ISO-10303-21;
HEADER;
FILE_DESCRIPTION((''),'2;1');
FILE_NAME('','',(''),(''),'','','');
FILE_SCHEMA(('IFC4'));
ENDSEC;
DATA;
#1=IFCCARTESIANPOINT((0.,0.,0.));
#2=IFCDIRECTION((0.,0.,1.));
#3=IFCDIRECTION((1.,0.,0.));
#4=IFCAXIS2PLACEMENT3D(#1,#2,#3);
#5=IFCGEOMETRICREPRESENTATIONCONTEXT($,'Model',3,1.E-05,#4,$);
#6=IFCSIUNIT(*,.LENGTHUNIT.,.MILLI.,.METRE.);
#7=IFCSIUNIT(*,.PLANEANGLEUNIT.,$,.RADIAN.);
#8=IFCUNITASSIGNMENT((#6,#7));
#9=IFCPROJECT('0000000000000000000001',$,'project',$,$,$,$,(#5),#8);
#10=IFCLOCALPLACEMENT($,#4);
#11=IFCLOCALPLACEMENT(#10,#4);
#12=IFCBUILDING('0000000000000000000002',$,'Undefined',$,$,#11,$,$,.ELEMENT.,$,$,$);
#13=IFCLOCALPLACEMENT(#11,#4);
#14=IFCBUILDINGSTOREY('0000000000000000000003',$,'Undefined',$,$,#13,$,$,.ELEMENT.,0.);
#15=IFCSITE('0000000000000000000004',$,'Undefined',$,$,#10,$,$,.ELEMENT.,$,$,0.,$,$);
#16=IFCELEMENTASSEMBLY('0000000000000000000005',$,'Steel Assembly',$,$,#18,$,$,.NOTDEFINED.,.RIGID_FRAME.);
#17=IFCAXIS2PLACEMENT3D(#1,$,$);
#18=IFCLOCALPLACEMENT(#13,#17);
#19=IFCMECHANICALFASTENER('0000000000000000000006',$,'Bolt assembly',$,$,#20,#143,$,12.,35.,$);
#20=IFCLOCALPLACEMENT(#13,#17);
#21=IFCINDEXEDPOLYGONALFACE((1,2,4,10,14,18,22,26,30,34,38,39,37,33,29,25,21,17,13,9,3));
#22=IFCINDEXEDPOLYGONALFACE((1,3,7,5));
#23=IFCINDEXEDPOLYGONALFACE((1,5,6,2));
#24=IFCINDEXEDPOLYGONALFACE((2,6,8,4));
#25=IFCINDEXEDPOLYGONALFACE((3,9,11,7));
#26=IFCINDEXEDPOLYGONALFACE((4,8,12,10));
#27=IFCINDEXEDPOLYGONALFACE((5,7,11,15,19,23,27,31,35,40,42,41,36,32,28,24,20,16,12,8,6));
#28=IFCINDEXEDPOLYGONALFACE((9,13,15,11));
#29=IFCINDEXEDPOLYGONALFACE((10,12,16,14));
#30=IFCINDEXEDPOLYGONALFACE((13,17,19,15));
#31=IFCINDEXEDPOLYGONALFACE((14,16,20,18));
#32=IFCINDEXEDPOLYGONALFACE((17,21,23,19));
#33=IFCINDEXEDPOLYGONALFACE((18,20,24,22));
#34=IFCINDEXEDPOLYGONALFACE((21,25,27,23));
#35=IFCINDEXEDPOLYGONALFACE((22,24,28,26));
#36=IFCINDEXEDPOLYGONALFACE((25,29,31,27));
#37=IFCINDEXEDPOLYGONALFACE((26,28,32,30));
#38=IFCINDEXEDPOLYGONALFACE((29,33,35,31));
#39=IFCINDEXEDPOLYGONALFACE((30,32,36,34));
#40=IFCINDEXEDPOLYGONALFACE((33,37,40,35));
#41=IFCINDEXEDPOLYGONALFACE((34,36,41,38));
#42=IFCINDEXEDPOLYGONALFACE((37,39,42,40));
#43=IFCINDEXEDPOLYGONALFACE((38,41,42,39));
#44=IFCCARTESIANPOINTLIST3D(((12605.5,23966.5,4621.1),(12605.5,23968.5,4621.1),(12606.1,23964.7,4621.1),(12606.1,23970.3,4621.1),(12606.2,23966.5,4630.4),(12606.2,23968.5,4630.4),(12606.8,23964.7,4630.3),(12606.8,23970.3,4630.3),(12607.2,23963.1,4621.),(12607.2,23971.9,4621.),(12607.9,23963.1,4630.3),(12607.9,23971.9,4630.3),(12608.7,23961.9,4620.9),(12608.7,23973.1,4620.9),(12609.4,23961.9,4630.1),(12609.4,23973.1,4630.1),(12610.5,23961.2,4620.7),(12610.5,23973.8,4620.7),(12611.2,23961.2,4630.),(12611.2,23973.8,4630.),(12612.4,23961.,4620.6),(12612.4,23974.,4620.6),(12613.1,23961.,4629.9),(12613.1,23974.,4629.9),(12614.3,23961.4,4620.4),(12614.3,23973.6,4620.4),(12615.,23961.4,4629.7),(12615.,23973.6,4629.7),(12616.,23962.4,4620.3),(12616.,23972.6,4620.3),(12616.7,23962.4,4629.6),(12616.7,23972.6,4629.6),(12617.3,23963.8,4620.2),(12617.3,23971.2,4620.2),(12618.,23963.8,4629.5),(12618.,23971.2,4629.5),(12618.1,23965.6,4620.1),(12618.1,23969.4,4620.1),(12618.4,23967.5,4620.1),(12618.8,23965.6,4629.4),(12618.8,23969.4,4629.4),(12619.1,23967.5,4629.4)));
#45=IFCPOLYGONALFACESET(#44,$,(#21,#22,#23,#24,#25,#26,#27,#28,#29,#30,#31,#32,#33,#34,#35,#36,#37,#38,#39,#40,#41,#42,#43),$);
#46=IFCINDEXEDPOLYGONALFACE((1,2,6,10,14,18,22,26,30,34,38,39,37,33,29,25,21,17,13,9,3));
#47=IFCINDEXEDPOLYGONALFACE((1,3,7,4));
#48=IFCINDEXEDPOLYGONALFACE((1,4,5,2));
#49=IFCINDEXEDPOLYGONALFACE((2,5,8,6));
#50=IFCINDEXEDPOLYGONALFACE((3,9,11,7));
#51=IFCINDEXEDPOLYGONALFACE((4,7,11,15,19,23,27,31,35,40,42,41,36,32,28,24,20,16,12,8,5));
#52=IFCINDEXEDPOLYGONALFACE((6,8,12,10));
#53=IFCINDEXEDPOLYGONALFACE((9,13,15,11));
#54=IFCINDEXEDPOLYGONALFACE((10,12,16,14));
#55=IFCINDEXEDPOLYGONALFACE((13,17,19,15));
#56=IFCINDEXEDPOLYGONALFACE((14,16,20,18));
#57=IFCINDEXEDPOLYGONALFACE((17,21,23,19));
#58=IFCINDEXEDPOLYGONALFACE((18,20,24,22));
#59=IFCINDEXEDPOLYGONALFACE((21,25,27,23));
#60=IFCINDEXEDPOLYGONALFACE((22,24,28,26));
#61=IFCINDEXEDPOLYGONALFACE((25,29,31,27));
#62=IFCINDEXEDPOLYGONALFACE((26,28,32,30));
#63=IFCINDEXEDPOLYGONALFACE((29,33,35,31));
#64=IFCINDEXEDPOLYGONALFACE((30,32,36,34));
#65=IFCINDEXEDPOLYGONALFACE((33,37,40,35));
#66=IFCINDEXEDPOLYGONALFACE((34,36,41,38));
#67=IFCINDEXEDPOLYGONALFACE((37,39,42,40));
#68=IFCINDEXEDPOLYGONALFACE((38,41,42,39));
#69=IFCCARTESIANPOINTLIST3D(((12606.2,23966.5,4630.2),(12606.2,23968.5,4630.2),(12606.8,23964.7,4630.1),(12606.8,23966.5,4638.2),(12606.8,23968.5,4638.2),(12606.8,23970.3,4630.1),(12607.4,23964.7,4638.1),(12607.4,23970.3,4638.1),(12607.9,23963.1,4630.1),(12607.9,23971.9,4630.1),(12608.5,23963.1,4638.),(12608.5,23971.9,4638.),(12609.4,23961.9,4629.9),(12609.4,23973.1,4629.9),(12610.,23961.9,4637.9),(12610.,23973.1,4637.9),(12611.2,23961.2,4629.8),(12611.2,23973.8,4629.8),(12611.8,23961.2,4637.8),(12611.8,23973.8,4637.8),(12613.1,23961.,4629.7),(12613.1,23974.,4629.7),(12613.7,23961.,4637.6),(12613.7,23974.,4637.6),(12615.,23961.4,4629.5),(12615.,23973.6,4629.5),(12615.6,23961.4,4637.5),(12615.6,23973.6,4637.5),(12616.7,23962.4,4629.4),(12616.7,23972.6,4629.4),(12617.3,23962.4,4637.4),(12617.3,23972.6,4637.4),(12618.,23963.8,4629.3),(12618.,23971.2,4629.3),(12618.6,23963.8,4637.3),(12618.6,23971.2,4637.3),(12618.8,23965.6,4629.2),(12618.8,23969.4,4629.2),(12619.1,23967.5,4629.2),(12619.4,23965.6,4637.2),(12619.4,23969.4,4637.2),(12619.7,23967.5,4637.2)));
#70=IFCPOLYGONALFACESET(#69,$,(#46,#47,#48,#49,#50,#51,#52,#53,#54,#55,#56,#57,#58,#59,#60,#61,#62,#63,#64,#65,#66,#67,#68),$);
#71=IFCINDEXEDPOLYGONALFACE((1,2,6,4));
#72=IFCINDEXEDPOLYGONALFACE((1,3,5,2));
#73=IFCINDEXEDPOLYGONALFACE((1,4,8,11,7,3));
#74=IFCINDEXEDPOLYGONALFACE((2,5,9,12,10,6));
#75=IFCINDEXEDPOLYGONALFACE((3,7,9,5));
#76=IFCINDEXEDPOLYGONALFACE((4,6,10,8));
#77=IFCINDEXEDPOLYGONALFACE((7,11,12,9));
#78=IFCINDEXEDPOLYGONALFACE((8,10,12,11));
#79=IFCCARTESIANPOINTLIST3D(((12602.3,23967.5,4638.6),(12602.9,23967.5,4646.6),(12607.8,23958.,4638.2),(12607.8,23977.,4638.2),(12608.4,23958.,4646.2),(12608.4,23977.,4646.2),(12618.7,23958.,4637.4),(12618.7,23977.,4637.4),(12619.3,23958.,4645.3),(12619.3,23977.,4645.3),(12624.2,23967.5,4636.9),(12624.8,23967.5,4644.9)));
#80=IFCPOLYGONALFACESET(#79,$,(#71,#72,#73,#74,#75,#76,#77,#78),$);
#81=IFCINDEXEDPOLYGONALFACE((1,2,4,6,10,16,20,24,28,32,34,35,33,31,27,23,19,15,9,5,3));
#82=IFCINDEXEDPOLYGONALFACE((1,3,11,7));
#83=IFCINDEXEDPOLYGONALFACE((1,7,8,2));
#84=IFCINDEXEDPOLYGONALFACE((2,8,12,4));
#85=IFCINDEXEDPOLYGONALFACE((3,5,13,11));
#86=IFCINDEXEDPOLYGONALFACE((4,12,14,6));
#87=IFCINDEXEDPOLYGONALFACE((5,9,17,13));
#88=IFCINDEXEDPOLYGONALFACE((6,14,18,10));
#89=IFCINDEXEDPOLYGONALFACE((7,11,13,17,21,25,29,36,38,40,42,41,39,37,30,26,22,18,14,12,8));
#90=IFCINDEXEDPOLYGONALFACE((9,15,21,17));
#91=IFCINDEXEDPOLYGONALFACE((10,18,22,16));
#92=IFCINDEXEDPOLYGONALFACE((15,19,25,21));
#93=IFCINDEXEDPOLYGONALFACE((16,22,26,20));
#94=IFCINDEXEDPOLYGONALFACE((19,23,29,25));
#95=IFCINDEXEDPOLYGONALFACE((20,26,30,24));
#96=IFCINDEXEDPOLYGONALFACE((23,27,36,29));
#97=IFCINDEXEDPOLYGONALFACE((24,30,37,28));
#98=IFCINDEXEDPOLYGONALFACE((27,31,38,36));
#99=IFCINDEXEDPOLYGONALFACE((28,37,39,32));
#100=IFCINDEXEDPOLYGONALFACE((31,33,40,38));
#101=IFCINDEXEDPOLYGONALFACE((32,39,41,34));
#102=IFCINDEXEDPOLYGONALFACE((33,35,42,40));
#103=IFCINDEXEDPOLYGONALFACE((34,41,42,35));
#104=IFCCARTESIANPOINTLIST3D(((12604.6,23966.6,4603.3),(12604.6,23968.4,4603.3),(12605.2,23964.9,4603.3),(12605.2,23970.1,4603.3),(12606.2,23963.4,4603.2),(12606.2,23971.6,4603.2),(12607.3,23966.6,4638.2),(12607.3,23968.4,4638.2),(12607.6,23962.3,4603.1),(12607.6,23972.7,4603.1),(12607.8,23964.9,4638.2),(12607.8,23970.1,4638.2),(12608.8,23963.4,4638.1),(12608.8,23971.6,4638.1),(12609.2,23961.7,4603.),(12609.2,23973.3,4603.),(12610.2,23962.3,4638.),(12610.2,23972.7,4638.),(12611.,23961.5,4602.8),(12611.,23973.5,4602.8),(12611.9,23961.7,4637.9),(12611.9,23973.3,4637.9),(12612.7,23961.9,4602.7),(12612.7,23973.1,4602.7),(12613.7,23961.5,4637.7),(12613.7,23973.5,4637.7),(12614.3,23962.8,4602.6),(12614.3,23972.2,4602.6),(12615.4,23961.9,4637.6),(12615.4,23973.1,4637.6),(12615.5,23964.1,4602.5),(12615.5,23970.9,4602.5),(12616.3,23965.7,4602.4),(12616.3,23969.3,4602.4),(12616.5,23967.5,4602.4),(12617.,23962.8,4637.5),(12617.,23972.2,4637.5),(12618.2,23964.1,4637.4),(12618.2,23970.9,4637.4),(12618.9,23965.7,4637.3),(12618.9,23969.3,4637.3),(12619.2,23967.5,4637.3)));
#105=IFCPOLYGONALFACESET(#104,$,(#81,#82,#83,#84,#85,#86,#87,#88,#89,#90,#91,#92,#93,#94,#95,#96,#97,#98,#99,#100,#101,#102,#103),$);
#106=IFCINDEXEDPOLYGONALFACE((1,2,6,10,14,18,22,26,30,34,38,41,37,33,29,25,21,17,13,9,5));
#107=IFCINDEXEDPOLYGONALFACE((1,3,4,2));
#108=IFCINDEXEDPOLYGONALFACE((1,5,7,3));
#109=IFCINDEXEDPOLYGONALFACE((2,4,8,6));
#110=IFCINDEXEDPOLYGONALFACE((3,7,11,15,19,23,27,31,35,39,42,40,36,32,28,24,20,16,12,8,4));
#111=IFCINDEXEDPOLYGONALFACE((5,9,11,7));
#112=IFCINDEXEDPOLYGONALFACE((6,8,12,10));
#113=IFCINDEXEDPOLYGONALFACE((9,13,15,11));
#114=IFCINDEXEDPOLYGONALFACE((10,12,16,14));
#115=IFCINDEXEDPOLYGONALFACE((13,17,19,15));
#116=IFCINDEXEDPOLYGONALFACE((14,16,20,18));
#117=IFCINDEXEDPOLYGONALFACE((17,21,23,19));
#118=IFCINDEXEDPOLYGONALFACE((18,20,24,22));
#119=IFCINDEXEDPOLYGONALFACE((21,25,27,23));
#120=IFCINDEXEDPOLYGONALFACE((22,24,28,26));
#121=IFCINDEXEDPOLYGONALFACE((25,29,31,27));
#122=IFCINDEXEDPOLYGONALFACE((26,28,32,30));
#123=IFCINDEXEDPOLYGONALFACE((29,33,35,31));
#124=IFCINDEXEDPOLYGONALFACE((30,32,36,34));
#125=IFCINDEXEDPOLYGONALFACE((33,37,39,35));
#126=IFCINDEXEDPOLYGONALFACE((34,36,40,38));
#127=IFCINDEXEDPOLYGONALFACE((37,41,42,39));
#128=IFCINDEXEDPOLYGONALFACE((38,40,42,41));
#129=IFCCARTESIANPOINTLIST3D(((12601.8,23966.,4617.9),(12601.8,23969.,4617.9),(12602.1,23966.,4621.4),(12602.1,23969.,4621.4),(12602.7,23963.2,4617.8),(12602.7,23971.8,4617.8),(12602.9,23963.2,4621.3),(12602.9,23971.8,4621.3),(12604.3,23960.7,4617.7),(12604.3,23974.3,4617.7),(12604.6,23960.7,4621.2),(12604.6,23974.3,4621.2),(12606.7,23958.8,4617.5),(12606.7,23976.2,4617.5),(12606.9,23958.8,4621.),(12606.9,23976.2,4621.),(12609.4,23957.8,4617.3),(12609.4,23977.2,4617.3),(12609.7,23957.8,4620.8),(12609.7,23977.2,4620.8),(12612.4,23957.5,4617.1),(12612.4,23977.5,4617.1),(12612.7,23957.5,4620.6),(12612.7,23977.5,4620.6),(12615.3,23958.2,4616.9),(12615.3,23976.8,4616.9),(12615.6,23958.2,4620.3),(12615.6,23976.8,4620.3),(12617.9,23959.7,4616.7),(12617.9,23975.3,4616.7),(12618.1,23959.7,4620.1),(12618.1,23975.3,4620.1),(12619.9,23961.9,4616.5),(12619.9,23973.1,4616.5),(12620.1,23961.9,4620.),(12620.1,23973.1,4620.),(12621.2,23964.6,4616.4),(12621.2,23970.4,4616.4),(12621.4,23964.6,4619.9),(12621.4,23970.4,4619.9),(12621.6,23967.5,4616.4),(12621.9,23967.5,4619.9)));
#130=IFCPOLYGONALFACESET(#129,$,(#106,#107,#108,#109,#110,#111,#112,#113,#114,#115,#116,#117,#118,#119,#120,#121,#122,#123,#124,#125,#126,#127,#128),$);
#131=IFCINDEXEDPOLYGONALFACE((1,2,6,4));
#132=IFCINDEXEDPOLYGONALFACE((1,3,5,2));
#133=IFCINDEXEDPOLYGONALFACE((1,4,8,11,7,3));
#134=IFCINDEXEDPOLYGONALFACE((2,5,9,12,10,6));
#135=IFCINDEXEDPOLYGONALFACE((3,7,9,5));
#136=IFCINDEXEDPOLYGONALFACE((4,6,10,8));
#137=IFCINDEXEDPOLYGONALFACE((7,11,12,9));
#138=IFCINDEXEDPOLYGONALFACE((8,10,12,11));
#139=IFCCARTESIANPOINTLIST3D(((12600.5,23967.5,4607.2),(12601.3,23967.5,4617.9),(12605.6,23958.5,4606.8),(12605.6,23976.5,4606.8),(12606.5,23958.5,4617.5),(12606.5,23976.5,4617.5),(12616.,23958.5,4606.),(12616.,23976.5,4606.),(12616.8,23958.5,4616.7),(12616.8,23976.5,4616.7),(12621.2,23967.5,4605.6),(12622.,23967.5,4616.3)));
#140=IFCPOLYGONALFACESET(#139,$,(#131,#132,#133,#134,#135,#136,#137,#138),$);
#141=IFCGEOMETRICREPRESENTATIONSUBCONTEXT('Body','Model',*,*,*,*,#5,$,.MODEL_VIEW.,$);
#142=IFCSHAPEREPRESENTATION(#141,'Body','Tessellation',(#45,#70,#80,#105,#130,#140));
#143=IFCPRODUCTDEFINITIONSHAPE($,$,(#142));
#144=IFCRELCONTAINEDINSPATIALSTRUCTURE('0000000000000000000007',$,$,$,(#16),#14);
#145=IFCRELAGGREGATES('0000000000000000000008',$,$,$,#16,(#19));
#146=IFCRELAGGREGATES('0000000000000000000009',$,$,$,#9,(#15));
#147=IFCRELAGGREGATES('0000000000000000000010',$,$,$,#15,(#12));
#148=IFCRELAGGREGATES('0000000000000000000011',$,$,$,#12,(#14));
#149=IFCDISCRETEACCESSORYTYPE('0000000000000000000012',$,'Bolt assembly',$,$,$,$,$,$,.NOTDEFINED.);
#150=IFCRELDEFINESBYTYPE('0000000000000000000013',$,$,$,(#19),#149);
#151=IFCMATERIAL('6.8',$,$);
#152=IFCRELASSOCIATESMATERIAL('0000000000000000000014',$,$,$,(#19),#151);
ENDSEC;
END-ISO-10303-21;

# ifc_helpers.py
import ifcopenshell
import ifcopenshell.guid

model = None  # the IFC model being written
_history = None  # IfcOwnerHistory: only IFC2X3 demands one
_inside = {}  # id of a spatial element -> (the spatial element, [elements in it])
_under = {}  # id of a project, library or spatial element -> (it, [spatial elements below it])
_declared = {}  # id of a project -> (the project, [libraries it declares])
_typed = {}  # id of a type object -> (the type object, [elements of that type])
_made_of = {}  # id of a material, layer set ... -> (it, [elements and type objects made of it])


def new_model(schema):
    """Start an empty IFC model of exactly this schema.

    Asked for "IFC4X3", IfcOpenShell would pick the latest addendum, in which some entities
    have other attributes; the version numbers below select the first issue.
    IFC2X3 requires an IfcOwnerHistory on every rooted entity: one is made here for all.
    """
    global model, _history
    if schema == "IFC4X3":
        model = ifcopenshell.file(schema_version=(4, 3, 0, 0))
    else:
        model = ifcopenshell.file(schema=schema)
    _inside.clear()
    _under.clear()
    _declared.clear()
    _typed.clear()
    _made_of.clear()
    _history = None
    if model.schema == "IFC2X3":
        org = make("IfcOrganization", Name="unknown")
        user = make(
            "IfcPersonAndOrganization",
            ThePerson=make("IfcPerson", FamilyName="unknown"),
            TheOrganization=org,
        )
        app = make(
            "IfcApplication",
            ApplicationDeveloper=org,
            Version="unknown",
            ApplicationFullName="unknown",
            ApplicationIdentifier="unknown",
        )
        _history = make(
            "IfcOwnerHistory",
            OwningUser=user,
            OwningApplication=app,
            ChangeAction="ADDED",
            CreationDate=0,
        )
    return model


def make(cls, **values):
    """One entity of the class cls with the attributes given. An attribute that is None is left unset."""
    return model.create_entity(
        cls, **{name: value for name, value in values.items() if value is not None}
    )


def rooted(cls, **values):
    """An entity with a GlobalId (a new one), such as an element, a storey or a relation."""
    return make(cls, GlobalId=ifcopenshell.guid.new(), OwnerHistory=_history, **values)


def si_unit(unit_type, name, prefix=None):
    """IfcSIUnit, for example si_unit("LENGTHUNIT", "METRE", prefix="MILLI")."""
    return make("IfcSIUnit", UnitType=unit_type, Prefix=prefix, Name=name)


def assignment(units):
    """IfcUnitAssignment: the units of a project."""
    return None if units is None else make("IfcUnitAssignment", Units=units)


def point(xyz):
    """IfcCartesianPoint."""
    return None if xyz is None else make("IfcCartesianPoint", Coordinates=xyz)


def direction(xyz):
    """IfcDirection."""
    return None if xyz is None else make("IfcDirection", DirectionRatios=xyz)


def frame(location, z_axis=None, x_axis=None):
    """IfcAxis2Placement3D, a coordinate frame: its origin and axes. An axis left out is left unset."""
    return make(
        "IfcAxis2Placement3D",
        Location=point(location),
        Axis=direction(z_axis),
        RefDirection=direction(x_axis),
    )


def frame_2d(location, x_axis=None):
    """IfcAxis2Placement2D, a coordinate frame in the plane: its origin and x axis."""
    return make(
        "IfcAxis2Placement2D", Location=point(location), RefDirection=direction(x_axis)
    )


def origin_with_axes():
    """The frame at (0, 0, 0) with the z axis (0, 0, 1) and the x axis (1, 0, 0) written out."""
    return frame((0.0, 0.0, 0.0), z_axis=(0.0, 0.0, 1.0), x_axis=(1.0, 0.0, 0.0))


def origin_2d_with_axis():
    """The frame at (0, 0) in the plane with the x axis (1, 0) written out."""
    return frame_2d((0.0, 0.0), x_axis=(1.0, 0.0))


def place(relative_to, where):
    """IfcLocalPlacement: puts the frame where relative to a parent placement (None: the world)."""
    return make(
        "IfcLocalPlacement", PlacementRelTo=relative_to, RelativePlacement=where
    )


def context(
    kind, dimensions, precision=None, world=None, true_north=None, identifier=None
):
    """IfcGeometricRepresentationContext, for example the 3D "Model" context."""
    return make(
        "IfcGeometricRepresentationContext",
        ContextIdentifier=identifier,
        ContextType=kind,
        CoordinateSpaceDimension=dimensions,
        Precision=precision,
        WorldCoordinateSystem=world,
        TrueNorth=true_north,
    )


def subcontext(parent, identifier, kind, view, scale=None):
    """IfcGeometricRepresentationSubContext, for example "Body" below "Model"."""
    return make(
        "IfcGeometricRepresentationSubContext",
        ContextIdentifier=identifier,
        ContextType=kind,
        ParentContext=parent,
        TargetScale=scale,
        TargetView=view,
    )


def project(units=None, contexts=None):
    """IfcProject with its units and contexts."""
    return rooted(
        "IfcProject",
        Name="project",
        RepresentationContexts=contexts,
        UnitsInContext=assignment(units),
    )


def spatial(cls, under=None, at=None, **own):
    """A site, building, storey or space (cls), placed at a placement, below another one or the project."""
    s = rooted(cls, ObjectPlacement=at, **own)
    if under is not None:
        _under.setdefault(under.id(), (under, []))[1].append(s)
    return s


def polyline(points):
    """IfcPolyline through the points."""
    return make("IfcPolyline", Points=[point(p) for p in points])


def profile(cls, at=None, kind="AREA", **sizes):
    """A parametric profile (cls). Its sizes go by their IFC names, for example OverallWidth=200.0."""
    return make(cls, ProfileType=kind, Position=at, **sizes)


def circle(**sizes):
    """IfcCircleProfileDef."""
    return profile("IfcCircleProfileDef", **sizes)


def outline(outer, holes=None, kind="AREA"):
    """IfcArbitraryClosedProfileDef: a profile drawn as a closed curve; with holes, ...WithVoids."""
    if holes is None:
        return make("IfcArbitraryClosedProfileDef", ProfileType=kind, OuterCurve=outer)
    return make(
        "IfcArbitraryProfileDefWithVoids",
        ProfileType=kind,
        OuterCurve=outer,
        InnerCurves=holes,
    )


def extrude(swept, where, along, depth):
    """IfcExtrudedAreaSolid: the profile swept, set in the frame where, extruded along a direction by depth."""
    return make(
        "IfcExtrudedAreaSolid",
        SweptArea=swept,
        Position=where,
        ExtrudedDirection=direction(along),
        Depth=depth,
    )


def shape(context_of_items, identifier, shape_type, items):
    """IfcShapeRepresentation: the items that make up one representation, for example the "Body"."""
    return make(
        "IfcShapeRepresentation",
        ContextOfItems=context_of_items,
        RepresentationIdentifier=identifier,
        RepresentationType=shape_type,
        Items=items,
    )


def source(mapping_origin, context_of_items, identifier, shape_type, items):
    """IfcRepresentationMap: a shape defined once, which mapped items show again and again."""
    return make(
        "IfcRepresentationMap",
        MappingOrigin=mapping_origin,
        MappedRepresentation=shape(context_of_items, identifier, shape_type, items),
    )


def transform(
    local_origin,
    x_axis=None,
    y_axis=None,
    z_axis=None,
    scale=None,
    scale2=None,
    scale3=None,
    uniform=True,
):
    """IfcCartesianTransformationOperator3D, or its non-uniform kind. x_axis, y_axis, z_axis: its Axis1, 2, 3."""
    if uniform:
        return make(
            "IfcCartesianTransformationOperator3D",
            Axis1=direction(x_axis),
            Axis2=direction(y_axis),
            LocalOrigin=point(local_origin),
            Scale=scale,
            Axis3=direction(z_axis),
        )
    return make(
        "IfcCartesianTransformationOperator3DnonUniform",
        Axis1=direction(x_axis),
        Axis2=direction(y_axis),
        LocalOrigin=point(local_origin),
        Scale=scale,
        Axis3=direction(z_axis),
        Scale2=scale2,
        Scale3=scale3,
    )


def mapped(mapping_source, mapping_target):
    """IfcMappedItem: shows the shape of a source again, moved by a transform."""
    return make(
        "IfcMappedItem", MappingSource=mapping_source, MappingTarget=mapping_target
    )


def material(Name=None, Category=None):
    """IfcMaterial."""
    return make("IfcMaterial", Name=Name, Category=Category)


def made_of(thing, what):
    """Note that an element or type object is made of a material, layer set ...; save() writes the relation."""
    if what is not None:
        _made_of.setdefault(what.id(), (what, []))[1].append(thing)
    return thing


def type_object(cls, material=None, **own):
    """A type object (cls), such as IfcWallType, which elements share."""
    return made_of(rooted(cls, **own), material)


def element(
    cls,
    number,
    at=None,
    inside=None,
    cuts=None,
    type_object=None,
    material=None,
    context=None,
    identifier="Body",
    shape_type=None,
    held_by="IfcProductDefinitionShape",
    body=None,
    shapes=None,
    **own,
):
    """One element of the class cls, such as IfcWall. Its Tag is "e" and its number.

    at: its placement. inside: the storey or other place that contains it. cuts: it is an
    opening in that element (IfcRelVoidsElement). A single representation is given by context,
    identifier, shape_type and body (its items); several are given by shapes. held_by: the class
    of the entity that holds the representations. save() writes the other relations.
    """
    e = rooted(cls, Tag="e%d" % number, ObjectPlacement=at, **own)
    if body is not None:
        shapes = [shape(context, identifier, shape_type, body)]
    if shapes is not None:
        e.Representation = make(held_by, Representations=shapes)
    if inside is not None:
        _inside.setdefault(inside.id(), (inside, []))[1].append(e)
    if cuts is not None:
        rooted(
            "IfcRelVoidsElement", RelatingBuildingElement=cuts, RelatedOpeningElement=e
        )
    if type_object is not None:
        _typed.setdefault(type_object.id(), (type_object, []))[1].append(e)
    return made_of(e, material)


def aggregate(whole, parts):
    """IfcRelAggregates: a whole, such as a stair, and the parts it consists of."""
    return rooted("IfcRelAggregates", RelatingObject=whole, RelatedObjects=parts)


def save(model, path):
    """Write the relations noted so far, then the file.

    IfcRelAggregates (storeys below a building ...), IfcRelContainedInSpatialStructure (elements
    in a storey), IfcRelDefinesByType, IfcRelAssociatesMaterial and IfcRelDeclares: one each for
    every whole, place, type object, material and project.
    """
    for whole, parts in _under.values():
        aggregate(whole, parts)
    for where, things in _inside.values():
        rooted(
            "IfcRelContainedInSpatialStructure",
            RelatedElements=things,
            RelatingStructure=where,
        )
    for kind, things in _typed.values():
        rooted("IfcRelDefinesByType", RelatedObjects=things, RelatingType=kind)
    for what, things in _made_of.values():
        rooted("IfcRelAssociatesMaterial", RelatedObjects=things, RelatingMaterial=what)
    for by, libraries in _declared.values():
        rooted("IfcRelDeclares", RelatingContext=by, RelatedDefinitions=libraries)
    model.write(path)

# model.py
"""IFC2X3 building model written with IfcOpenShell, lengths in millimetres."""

from ifc_helpers import new_model, si_unit, frame, origin_with_axes, origin_2d_with_axis, place, context, subcontext, project, spatial, polyline, circle, outline, extrude, source, transform, mapped, material, type_object, element, aggregate, save


model = new_model("IFC2X3")

# Units and contexts
model_context = context("Model", 3, precision=1e-05, world=origin_with_axes())
body_context = subcontext(model_context, "Body", "Model", "MODEL_VIEW")
ifc_project = project(units=[si_unit("LENGTHUNIT", "METRE", prefix="MILLI"), si_unit("PLANEANGLEUNIT", "RADIAN")], contexts=[model_context])

# Site, building, storey
site_placement = place(None, origin_with_axes())
site = spatial("IfcSite", under=ifc_project, at=site_placement, Name="Undefined", CompositionType="ELEMENT", RefElevation=0.0)
building_placement = place(site_placement, origin_with_axes())
building = spatial("IfcBuilding", under=site, at=building_placement, Name="Undefined", CompositionType="ELEMENT")
storey_placement = place(building_placement, origin_with_axes())
storey = spatial("IfcBuildingStorey", under=building, at=storey_placement, Name="Undefined", CompositionType="ELEMENT", Elevation=0.0)

# Shared definitions
ifc_material_1 = material(Name="6.8")
discrete_accessory_type_1 = type_object("IfcDiscreteAccessoryType", Name="Bolt assembly")

# Element assembly, mechanical fastener
assembly_1_placement = place(storey_placement, origin_with_axes())
assembly_1 = element("IfcElementAssembly", 1, at=assembly_1_placement, inside=storey, Name="Steel Assembly", AssemblyPlace="NOTDEFINED", PredefinedType="RIGID_FRAME")
shared_shape_1 = source(origin_with_axes(), body_context, "Body", "SweptSolid", [
    extrude(circle(Radius=6.5, at=origin_2d_with_axis()), frame((0.0, -0.1, 0.0), z_axis=(0.0, 1.0, 0.0), x_axis=(1.0, 0.0, 0.0)), (0.0, 0.0, 1.0), 9.3),
    extrude(circle(Radius=6.5, at=origin_2d_with_axis()), frame((0.0, -7.9, 0.0), z_axis=(0.0, 1.0, 0.0), x_axis=(1.0, 0.0, 0.0)), (0.0, 0.0, 1.0), 8.0),
    extrude(outline(polyline([(11.0, 0.0), (5.5, 9.5), (-5.5, 9.5), (-11.0, 0.0), (-5.5, -9.5), (5.5, -9.5), (11.0, 0.0)])), frame((0.0, -16.0, 0.0), z_axis=(0.0, 1.0, 0.0), x_axis=(1.0, 0.0, 0.0)), (0.0, 0.0, 1.0), 8.0),
    extrude(circle(Radius=6.0, at=origin_2d_with_axis()), frame((0.0, -8.0, 0.0), z_axis=(0.0, 1.0, 0.0), x_axis=(1.0, 0.0, 0.0)), (0.0, 0.0, 1.0), 35.0),
    extrude(circle(Radius=10.0, at=origin_2d_with_axis()), frame((0.0, 9.2, 0.0), z_axis=(0.0, 1.0, 0.0), x_axis=(1.0, 0.0, 0.0)), (0.0, 0.0, 1.0), 3.5),
    extrude(outline(polyline([(10.4, 0.0), (5.2, 9.0), (-5.2, 9.0), (-10.4, 0.0), (-5.2, -9.0), (5.2, -9.0), (10.4, 0.0)])), frame((0.0, 12.7, 0.0), z_axis=(0.0, 1.0, 0.0), x_axis=(1.0, 0.0, 0.0)), (0.0, 0.0, 1.0), 10.8),
])
mechanical_fastener_1_placement = place(assembly_1_placement, frame((12612.6, 23967.5, 4629.8), z_axis=(0.0, 1.0, 0.0), x_axis=(0.997054, 0.0, -0.076696)))
mechanical_fastener_1 = element("IfcMechanicalFastener", 2, at=mechanical_fastener_1_placement, type_object=discrete_accessory_type_1, material=ifc_material_1, Name="Bolt assembly", NominalDiameter=12.0, NominalLength=35.0, context=body_context, shape_type="MappedRepresentation", body=[
    mapped(shared_shape_1, transform((0.0, 0.0, 0.0))),
])
aggregate(assembly_1, [mechanical_fastener_1])

save(model, "model.ifc")
